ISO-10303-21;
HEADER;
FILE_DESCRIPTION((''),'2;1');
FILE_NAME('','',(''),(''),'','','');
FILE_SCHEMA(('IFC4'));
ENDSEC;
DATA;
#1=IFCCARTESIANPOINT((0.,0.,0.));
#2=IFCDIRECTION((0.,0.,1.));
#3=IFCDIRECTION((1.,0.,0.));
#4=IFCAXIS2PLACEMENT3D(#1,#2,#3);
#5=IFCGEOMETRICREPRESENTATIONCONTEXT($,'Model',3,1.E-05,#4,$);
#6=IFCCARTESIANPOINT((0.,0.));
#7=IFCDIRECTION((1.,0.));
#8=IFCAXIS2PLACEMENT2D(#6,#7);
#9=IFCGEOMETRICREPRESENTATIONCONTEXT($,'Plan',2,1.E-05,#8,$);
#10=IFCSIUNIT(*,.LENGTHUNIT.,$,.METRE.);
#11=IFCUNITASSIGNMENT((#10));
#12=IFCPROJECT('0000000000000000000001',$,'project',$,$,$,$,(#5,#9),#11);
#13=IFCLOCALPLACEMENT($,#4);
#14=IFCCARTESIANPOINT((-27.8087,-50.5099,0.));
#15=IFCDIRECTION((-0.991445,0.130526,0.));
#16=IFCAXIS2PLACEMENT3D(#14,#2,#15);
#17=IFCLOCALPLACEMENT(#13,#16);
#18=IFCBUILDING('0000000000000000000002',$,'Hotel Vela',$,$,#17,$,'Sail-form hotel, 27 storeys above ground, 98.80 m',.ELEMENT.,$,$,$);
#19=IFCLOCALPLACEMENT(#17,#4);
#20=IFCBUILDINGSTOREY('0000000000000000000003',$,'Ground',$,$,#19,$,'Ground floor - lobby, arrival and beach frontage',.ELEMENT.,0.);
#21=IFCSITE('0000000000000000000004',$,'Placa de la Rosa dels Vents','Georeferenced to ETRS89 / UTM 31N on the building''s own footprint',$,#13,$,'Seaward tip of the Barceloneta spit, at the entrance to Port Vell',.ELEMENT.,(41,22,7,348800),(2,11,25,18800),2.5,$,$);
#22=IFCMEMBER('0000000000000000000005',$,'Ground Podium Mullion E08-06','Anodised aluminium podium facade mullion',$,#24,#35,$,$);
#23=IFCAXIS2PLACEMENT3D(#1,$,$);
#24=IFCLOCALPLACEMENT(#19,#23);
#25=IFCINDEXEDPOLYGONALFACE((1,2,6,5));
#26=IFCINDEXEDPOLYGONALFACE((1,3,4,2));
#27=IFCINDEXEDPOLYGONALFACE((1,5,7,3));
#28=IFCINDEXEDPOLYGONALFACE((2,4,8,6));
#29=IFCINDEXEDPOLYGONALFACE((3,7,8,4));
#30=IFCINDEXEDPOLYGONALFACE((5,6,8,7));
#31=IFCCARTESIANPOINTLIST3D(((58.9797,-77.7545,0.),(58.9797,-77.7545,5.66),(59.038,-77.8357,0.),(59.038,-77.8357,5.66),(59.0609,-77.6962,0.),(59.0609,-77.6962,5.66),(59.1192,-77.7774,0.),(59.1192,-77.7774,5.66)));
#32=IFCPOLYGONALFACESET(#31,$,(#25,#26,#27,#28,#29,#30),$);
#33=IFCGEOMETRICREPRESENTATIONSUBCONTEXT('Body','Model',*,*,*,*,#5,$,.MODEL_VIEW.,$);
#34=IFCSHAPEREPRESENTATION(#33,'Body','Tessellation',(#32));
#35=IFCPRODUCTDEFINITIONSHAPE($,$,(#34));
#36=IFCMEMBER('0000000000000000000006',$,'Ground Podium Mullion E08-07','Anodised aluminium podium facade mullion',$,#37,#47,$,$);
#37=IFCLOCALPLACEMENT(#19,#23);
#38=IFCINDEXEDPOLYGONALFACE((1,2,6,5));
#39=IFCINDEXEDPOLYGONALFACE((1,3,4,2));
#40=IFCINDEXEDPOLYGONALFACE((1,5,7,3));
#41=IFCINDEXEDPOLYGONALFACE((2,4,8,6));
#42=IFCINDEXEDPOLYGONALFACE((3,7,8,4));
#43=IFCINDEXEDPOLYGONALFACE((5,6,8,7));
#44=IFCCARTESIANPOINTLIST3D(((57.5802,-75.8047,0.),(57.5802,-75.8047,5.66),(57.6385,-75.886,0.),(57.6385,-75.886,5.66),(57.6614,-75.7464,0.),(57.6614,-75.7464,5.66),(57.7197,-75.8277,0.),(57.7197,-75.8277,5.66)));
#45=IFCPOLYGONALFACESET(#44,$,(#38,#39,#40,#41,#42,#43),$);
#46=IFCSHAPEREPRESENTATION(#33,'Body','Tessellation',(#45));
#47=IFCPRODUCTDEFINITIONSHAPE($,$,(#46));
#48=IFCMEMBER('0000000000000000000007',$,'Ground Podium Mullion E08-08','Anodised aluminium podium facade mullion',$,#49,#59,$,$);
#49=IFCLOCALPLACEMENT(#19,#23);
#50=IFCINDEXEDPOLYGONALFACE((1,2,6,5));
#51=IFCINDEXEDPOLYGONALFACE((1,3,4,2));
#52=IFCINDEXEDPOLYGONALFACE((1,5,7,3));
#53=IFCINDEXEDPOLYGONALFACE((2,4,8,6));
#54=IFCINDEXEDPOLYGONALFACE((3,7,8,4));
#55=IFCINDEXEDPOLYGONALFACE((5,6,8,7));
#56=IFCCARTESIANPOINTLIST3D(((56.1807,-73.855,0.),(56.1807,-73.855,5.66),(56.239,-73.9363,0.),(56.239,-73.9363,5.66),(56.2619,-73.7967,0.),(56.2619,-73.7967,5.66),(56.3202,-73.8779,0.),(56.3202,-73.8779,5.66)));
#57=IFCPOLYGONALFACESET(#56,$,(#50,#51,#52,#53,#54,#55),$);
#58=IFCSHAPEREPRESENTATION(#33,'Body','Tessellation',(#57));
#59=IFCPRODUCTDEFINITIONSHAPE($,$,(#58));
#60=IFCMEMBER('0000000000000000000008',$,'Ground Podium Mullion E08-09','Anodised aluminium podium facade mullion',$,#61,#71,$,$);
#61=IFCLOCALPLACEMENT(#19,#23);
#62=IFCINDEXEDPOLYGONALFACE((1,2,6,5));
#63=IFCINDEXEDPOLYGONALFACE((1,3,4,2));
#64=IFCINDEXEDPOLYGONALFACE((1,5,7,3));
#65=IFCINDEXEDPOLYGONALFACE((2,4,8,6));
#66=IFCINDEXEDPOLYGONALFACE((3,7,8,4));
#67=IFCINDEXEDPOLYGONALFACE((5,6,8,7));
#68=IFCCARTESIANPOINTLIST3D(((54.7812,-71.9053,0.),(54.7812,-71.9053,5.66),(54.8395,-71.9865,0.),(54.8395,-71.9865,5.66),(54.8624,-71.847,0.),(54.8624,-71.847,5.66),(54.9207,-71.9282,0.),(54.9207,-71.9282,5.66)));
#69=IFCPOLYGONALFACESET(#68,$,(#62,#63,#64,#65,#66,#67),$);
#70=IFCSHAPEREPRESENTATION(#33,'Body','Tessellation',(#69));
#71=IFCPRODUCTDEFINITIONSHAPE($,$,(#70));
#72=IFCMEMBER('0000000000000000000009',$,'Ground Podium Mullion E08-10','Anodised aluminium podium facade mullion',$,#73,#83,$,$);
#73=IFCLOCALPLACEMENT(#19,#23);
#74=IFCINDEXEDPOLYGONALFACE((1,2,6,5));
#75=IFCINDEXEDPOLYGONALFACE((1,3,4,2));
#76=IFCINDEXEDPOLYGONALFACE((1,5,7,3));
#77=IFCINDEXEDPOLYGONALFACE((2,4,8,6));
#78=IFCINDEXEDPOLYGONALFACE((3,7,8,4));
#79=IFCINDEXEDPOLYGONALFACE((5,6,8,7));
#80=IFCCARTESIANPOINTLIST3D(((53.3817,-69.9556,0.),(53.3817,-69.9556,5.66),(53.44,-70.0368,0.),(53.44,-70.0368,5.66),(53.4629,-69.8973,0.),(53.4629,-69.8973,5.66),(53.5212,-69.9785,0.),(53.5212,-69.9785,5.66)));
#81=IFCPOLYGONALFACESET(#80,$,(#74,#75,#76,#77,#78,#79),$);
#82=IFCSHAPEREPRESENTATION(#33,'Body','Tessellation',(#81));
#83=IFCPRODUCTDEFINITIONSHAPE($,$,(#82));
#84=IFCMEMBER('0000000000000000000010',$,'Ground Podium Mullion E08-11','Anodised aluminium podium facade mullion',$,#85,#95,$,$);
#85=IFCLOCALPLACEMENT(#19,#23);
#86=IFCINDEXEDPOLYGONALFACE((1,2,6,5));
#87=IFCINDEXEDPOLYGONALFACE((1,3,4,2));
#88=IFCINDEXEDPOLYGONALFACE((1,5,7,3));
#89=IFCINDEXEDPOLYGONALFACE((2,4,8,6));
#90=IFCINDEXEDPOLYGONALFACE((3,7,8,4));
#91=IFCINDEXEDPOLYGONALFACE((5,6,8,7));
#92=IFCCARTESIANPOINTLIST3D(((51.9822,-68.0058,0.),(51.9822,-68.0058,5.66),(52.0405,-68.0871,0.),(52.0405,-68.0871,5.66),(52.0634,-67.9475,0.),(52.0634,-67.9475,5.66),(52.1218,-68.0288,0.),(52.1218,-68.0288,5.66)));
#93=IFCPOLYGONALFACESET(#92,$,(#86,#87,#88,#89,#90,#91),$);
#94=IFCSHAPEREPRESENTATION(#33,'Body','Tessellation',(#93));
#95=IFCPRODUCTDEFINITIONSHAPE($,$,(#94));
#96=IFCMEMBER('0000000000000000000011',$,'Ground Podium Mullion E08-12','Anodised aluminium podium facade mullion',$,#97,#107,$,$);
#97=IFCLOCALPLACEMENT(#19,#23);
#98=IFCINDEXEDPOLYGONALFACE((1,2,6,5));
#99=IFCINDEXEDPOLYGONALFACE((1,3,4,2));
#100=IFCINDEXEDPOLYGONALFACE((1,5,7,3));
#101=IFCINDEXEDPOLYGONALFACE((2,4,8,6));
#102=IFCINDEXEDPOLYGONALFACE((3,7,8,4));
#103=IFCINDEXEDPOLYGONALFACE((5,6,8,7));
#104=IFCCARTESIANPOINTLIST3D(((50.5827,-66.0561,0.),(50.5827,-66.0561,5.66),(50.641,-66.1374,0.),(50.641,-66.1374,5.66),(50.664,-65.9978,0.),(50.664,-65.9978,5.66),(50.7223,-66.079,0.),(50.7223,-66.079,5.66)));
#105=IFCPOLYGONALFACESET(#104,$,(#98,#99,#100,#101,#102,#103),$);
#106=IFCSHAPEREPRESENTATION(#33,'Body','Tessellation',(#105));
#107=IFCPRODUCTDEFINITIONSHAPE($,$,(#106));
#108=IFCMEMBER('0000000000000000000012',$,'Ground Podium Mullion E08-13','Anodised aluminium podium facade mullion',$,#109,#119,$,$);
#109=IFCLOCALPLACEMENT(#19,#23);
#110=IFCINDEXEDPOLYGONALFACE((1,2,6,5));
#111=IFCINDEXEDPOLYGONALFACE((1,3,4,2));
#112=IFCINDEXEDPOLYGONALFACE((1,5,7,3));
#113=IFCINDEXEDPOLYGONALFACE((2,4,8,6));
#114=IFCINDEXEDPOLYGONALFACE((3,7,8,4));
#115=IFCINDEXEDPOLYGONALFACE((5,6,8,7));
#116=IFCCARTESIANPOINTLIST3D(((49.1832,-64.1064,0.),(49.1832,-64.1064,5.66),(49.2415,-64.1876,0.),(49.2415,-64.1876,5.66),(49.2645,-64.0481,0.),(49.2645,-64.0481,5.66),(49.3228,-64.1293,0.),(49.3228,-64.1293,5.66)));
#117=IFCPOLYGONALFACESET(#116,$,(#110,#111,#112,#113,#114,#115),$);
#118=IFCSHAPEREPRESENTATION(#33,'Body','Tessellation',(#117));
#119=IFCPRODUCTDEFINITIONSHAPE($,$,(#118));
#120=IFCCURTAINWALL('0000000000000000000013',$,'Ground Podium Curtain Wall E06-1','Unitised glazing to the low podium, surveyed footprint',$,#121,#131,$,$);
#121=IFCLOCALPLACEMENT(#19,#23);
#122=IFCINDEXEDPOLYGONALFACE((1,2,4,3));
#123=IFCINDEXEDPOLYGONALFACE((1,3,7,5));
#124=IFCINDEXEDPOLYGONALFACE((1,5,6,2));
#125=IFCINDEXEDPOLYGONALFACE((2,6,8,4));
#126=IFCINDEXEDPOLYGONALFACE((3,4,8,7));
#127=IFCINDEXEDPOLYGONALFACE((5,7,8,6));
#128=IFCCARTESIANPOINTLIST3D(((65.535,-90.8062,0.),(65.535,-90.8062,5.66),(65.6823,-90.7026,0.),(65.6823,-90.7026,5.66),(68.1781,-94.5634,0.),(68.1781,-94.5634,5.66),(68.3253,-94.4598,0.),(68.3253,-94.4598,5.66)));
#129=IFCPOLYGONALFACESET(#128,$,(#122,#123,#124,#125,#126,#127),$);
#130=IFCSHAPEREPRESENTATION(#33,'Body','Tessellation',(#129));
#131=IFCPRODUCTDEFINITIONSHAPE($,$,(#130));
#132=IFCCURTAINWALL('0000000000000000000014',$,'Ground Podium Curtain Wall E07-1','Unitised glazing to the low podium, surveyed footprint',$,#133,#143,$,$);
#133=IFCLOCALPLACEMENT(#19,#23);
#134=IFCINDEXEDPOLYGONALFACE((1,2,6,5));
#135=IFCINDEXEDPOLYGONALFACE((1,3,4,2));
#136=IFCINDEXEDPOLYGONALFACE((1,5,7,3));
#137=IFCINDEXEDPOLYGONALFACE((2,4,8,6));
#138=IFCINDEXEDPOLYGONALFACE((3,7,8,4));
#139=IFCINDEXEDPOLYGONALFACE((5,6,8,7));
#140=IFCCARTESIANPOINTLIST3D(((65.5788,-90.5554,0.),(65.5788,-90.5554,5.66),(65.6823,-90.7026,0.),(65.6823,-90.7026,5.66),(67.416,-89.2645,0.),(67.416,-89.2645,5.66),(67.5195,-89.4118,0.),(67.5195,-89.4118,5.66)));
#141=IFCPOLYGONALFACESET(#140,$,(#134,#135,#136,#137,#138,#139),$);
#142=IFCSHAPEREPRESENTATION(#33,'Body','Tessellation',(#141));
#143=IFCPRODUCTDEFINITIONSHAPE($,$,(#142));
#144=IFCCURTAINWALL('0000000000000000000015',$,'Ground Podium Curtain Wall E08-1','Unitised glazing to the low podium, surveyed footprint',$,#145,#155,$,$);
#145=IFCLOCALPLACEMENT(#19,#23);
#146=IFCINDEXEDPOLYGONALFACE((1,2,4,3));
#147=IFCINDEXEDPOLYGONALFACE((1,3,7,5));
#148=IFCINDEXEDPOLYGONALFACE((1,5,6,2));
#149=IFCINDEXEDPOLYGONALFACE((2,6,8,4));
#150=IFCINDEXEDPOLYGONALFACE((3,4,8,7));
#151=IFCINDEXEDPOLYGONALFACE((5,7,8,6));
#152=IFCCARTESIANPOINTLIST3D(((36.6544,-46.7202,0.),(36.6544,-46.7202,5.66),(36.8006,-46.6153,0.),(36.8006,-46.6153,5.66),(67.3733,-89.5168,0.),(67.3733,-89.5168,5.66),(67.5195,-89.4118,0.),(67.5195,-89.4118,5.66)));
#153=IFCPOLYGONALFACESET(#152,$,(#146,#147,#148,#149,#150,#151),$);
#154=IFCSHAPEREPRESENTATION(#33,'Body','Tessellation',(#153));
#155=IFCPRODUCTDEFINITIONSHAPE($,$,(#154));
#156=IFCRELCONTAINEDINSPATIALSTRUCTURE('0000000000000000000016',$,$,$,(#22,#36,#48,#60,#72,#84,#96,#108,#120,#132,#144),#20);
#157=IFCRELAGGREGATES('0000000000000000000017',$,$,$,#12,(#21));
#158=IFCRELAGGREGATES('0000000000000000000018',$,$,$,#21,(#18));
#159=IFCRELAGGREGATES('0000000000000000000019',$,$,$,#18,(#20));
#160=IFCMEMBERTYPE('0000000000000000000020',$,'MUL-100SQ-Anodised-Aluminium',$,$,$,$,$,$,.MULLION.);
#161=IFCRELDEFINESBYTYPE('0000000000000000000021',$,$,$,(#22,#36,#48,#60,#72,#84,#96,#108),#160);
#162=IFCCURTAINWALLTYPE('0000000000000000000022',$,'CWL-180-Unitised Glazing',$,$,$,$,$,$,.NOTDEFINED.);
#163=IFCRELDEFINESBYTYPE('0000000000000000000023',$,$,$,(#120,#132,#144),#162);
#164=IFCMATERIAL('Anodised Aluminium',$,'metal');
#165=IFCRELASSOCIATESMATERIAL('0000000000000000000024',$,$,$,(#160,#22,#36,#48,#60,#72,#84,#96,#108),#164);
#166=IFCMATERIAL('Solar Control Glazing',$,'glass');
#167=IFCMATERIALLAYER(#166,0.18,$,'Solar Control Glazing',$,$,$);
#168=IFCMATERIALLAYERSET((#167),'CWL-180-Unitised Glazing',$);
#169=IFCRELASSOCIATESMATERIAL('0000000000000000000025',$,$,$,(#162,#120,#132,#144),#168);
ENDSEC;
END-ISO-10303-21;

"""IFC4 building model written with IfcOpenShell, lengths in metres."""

from ifc_helpers import new_model, si_unit, frame, origin_with_axes, origin_2d_with_axis, place, context, subcontext, project, spatial, line, indexed_curve, rectangle, outline, extrude, material, layer, layer_set, layer_usage, material_profile, profile_set, profile_usage, type_object, element, save


model = new_model("IFC4")

# Units and contexts
model_context = context("Model", 3, precision=1e-05, world=origin_with_axes())
plan_context = context("Plan", 2, precision=1e-05, world=origin_2d_with_axis())
body_context = subcontext(model_context, "Body", "Model", "MODEL_VIEW")
ifc_project = project(units=[si_unit("LENGTHUNIT", "METRE")], contexts=[model_context, plan_context])

# Site, building, storey
site_placement = place(None, origin_with_axes())
site = spatial("IfcSite", under=ifc_project, at=site_placement, Name="Placa de la Rosa dels Vents", Description="Georeferenced to ETRS89 / UTM 31N on the building's own footprint", LongName="Seaward tip of the Barceloneta spit, at the entrance to Port Vell", CompositionType="ELEMENT", RefLatitude=(41, 22, 7, 348800), RefLongitude=(2, 11, 25, 18800), RefElevation=2.5)
building_placement = place(site_placement, frame((-27.8087, -50.5099, 0.0), z_axis=(0.0, 0.0, 1.0), x_axis=(-0.991445, 0.130526, 0.0)))
building = spatial("IfcBuilding", under=site, at=building_placement, Name="Hotel Vela", LongName="Sail-form hotel, 27 storeys above ground, 98.80 m", CompositionType="ELEMENT")
storey_placement = place(building_placement, origin_with_axes())
storey = spatial("IfcBuildingStorey", under=building, at=storey_placement, Name="Ground", LongName="Ground floor - lobby, arrival and beach frontage", CompositionType="ELEMENT", Elevation=0.0)

# Members
ifc_material_1 = material(Name="Anodised Aluminium", Category="metal")
ifc_material_profile = material_profile(ifc_material_1, rectangle(XDim=0.1, YDim=0.1))
ifc_profile_set = profile_set([ifc_material_profile], Name="MUL-100SQ-Anodised-Aluminium")
member_type = type_object("IfcMemberType", Name="MUL-100SQ-Anodised-Aluminium", PredefinedType="MULLION", material=ifc_profile_set)
ifc_profile_usage_1 = profile_usage(ifc_profile_set)
member_1_placement = place(storey_placement, frame((59.1192, -77.7774, 0.0), z_axis=(0.0, 0.0, 1.0), x_axis=(-0.583121, 0.812385, 0.0)))
element("IfcMember", 1, at=member_1_placement, inside=storey, type_object=member_type, material=ifc_profile_usage_1, Name="Ground Podium Mullion E08-06", Description="Anodised aluminium podium facade mullion", context=body_context, shape_type="SweptSolid", body=[
    extrude(outline(indexed_curve([(0.0, 0.0), (0.1, 0.0), (0.1, 0.1), (0.0, 0.1)], segments=[line(1, 2, 3, 4, 1)])), origin_with_axes(), (0.0, 0.0, 1.0), 5.66),
])
ifc_profile_usage_2 = profile_usage(ifc_profile_set)
member_2_placement = place(storey_placement, frame((57.7197, -75.8277, 0.0), z_axis=(0.0, 0.0, 1.0), x_axis=(-0.583121, 0.812385, 0.0)))
element("IfcMember", 2, at=member_2_placement, inside=storey, type_object=member_type, material=ifc_profile_usage_2, Name="Ground Podium Mullion E08-07", Description="Anodised aluminium podium facade mullion", context=body_context, shape_type="SweptSolid", body=[
    extrude(outline(indexed_curve([(0.0, 0.0), (0.1, 0.0), (0.1, 0.1), (0.0, 0.1)], segments=[line(1, 2, 3, 4, 1)])), origin_with_axes(), (0.0, 0.0, 1.0), 5.66),
])
ifc_profile_usage_3 = profile_usage(ifc_profile_set)
member_3_placement = place(storey_placement, frame((56.3202, -73.8779, 0.0), z_axis=(0.0, 0.0, 1.0), x_axis=(-0.583121, 0.812385, 0.0)))
element("IfcMember", 3, at=member_3_placement, inside=storey, type_object=member_type, material=ifc_profile_usage_3, Name="Ground Podium Mullion E08-08", Description="Anodised aluminium podium facade mullion", context=body_context, shape_type="SweptSolid", body=[
    extrude(outline(indexed_curve([(0.0, 0.0), (0.1, 0.0), (0.1, 0.1), (0.0, 0.1)], segments=[line(1, 2, 3, 4, 1)])), origin_with_axes(), (0.0, 0.0, 1.0), 5.66),
])
ifc_profile_usage_4 = profile_usage(ifc_profile_set)
member_4_placement = place(storey_placement, frame((54.9207, -71.9282, 0.0), z_axis=(0.0, 0.0, 1.0), x_axis=(-0.583121, 0.812385, 0.0)))
element("IfcMember", 4, at=member_4_placement, inside=storey, type_object=member_type, material=ifc_profile_usage_4, Name="Ground Podium Mullion E08-09", Description="Anodised aluminium podium facade mullion", context=body_context, shape_type="SweptSolid", body=[
    extrude(outline(indexed_curve([(0.0, 0.0), (0.1, 0.0), (0.1, 0.1), (0.0, 0.1)], segments=[line(1, 2, 3, 4, 1)])), origin_with_axes(), (0.0, 0.0, 1.0), 5.66),
])
ifc_profile_usage_5 = profile_usage(ifc_profile_set)
member_5_placement = place(storey_placement, frame((53.5212, -69.9785, 0.0), z_axis=(0.0, 0.0, 1.0), x_axis=(-0.583121, 0.812385, 0.0)))
element("IfcMember", 5, at=member_5_placement, inside=storey, type_object=member_type, material=ifc_profile_usage_5, Name="Ground Podium Mullion E08-10", Description="Anodised aluminium podium facade mullion", context=body_context, shape_type="SweptSolid", body=[
    extrude(outline(indexed_curve([(0.0, 0.0), (0.1, 0.0), (0.1, 0.1), (0.0, 0.1)], segments=[line(1, 2, 3, 4, 1)])), origin_with_axes(), (0.0, 0.0, 1.0), 5.66),
])
ifc_profile_usage_6 = profile_usage(ifc_profile_set)
member_6_placement = place(storey_placement, frame((52.1218, -68.0288, 0.0), z_axis=(0.0, 0.0, 1.0), x_axis=(-0.583121, 0.812385, 0.0)))
element("IfcMember", 6, at=member_6_placement, inside=storey, type_object=member_type, material=ifc_profile_usage_6, Name="Ground Podium Mullion E08-11", Description="Anodised aluminium podium facade mullion", context=body_context, shape_type="SweptSolid", body=[
    extrude(outline(indexed_curve([(0.0, 0.0), (0.1, 0.0), (0.1, 0.1), (0.0, 0.1)], segments=[line(1, 2, 3, 4, 1)])), origin_with_axes(), (0.0, 0.0, 1.0), 5.66),
])
ifc_profile_usage_7 = profile_usage(ifc_profile_set)
member_7_placement = place(storey_placement, frame((50.7223, -66.079, 0.0), z_axis=(0.0, 0.0, 1.0), x_axis=(-0.583121, 0.812385, 0.0)))
element("IfcMember", 7, at=member_7_placement, inside=storey, type_object=member_type, material=ifc_profile_usage_7, Name="Ground Podium Mullion E08-12", Description="Anodised aluminium podium facade mullion", context=body_context, shape_type="SweptSolid", body=[
    extrude(outline(indexed_curve([(0.0, 0.0), (0.1, 0.0), (0.1, 0.1), (0.0, 0.1)], segments=[line(1, 2, 3, 4, 1)])), origin_with_axes(), (0.0, 0.0, 1.0), 5.66),
])
ifc_profile_usage_8 = profile_usage(ifc_profile_set)
member_8_placement = place(storey_placement, frame((49.3228, -64.1293, 0.0), z_axis=(0.0, 0.0, 1.0), x_axis=(-0.583121, 0.812385, 0.0)))
element("IfcMember", 8, at=member_8_placement, inside=storey, type_object=member_type, material=ifc_profile_usage_8, Name="Ground Podium Mullion E08-13", Description="Anodised aluminium podium facade mullion", context=body_context, shape_type="SweptSolid", body=[
    extrude(outline(indexed_curve([(0.0, 0.0), (0.1, 0.0), (0.1, 0.1), (0.0, 0.1)], segments=[line(1, 2, 3, 4, 1)])), origin_with_axes(), (0.0, 0.0, 1.0), 5.66),
])

# Curtain walls
ifc_material_2 = material(Name="Solar Control Glazing", Category="glass")
ifc_layer = layer(ifc_material_2, 0.18, Name="Solar Control Glazing")
ifc_layer_set = layer_set([ifc_layer], Name="CWL-180-Unitised Glazing")
ifc_layer_usage_1 = layer_usage(ifc_layer_set, "AXIS2", "POSITIVE", 0.0)
curtain_wall_type = type_object("IfcCurtainWallType", Name="CWL-180-Unitised Glazing", PredefinedType="NOTDEFINED", material=ifc_layer_set)
curtain_wall_1_placement = place(storey_placement, frame((68.3253, -94.4598, 0.0), z_axis=(0.0, 0.0, 1.0), x_axis=(-0.575361, 0.817899, 0.0)))
element("IfcCurtainWall", 9, at=curtain_wall_1_placement, inside=storey, type_object=curtain_wall_type, material=ifc_layer_usage_1, Name="Ground Podium Curtain Wall E06-1", Description="Unitised glazing to the low podium, surveyed footprint", context=body_context, shape_type="SweptSolid", body=[
    extrude(outline(indexed_curve([(0.0, 0.0), (4.5937, 0.0), (4.5937, 0.18), (0.0, 0.18)], segments=[line(1, 2, 3, 4, 1)])), origin_with_axes(), (0.0, 0.0, 1.0), 5.66),
])
ifc_layer_usage_2 = layer_usage(ifc_layer_set, "AXIS2", "POSITIVE", 0.0)
curtain_wall_2_placement = place(storey_placement, frame((65.6823, -90.7026, 0.0), z_axis=(0.0, 0.0, 1.0), x_axis=(0.818228, 0.574893, 0.0)))
element("IfcCurtainWall", 10, at=curtain_wall_2_placement, inside=storey, type_object=curtain_wall_type, material=ifc_layer_usage_2, Name="Ground Podium Curtain Wall E07-1", Description="Unitised glazing to the low podium, surveyed footprint", context=body_context, shape_type="SweptSolid", body=[
    extrude(outline(indexed_curve([(0.0, 0.0), (2.2454, 0.0), (2.2454, 0.18), (0.0, 0.18)], segments=[line(1, 2, 3, 4, 1)])), origin_with_axes(), (0.0, 0.0, 1.0), 5.66),
])
ifc_layer_usage_3 = layer_usage(ifc_layer_set, "AXIS2", "POSITIVE", 0.0)
curtain_wall_3_placement = place(storey_placement, frame((67.5195, -89.4118, 0.0), z_axis=(0.0, 0.0, 1.0), x_axis=(-0.583121, 0.812385, 0.0)))
element("IfcCurtainWall", 11, at=curtain_wall_3_placement, inside=storey, type_object=curtain_wall_type, material=ifc_layer_usage_3, Name="Ground Podium Curtain Wall E08-1", Description="Unitised glazing to the low podium, surveyed footprint", context=body_context, shape_type="SweptSolid", body=[
    extrude(outline(indexed_curve([(0.0, 0.0), (52.6801, 0.0), (52.6801, 0.18), (0.0, 0.18)], segments=[line(1, 2, 3, 4, 1)])), origin_with_axes(), (0.0, 0.0, 1.0), 5.66),
])

save(model, "model.ifc")
